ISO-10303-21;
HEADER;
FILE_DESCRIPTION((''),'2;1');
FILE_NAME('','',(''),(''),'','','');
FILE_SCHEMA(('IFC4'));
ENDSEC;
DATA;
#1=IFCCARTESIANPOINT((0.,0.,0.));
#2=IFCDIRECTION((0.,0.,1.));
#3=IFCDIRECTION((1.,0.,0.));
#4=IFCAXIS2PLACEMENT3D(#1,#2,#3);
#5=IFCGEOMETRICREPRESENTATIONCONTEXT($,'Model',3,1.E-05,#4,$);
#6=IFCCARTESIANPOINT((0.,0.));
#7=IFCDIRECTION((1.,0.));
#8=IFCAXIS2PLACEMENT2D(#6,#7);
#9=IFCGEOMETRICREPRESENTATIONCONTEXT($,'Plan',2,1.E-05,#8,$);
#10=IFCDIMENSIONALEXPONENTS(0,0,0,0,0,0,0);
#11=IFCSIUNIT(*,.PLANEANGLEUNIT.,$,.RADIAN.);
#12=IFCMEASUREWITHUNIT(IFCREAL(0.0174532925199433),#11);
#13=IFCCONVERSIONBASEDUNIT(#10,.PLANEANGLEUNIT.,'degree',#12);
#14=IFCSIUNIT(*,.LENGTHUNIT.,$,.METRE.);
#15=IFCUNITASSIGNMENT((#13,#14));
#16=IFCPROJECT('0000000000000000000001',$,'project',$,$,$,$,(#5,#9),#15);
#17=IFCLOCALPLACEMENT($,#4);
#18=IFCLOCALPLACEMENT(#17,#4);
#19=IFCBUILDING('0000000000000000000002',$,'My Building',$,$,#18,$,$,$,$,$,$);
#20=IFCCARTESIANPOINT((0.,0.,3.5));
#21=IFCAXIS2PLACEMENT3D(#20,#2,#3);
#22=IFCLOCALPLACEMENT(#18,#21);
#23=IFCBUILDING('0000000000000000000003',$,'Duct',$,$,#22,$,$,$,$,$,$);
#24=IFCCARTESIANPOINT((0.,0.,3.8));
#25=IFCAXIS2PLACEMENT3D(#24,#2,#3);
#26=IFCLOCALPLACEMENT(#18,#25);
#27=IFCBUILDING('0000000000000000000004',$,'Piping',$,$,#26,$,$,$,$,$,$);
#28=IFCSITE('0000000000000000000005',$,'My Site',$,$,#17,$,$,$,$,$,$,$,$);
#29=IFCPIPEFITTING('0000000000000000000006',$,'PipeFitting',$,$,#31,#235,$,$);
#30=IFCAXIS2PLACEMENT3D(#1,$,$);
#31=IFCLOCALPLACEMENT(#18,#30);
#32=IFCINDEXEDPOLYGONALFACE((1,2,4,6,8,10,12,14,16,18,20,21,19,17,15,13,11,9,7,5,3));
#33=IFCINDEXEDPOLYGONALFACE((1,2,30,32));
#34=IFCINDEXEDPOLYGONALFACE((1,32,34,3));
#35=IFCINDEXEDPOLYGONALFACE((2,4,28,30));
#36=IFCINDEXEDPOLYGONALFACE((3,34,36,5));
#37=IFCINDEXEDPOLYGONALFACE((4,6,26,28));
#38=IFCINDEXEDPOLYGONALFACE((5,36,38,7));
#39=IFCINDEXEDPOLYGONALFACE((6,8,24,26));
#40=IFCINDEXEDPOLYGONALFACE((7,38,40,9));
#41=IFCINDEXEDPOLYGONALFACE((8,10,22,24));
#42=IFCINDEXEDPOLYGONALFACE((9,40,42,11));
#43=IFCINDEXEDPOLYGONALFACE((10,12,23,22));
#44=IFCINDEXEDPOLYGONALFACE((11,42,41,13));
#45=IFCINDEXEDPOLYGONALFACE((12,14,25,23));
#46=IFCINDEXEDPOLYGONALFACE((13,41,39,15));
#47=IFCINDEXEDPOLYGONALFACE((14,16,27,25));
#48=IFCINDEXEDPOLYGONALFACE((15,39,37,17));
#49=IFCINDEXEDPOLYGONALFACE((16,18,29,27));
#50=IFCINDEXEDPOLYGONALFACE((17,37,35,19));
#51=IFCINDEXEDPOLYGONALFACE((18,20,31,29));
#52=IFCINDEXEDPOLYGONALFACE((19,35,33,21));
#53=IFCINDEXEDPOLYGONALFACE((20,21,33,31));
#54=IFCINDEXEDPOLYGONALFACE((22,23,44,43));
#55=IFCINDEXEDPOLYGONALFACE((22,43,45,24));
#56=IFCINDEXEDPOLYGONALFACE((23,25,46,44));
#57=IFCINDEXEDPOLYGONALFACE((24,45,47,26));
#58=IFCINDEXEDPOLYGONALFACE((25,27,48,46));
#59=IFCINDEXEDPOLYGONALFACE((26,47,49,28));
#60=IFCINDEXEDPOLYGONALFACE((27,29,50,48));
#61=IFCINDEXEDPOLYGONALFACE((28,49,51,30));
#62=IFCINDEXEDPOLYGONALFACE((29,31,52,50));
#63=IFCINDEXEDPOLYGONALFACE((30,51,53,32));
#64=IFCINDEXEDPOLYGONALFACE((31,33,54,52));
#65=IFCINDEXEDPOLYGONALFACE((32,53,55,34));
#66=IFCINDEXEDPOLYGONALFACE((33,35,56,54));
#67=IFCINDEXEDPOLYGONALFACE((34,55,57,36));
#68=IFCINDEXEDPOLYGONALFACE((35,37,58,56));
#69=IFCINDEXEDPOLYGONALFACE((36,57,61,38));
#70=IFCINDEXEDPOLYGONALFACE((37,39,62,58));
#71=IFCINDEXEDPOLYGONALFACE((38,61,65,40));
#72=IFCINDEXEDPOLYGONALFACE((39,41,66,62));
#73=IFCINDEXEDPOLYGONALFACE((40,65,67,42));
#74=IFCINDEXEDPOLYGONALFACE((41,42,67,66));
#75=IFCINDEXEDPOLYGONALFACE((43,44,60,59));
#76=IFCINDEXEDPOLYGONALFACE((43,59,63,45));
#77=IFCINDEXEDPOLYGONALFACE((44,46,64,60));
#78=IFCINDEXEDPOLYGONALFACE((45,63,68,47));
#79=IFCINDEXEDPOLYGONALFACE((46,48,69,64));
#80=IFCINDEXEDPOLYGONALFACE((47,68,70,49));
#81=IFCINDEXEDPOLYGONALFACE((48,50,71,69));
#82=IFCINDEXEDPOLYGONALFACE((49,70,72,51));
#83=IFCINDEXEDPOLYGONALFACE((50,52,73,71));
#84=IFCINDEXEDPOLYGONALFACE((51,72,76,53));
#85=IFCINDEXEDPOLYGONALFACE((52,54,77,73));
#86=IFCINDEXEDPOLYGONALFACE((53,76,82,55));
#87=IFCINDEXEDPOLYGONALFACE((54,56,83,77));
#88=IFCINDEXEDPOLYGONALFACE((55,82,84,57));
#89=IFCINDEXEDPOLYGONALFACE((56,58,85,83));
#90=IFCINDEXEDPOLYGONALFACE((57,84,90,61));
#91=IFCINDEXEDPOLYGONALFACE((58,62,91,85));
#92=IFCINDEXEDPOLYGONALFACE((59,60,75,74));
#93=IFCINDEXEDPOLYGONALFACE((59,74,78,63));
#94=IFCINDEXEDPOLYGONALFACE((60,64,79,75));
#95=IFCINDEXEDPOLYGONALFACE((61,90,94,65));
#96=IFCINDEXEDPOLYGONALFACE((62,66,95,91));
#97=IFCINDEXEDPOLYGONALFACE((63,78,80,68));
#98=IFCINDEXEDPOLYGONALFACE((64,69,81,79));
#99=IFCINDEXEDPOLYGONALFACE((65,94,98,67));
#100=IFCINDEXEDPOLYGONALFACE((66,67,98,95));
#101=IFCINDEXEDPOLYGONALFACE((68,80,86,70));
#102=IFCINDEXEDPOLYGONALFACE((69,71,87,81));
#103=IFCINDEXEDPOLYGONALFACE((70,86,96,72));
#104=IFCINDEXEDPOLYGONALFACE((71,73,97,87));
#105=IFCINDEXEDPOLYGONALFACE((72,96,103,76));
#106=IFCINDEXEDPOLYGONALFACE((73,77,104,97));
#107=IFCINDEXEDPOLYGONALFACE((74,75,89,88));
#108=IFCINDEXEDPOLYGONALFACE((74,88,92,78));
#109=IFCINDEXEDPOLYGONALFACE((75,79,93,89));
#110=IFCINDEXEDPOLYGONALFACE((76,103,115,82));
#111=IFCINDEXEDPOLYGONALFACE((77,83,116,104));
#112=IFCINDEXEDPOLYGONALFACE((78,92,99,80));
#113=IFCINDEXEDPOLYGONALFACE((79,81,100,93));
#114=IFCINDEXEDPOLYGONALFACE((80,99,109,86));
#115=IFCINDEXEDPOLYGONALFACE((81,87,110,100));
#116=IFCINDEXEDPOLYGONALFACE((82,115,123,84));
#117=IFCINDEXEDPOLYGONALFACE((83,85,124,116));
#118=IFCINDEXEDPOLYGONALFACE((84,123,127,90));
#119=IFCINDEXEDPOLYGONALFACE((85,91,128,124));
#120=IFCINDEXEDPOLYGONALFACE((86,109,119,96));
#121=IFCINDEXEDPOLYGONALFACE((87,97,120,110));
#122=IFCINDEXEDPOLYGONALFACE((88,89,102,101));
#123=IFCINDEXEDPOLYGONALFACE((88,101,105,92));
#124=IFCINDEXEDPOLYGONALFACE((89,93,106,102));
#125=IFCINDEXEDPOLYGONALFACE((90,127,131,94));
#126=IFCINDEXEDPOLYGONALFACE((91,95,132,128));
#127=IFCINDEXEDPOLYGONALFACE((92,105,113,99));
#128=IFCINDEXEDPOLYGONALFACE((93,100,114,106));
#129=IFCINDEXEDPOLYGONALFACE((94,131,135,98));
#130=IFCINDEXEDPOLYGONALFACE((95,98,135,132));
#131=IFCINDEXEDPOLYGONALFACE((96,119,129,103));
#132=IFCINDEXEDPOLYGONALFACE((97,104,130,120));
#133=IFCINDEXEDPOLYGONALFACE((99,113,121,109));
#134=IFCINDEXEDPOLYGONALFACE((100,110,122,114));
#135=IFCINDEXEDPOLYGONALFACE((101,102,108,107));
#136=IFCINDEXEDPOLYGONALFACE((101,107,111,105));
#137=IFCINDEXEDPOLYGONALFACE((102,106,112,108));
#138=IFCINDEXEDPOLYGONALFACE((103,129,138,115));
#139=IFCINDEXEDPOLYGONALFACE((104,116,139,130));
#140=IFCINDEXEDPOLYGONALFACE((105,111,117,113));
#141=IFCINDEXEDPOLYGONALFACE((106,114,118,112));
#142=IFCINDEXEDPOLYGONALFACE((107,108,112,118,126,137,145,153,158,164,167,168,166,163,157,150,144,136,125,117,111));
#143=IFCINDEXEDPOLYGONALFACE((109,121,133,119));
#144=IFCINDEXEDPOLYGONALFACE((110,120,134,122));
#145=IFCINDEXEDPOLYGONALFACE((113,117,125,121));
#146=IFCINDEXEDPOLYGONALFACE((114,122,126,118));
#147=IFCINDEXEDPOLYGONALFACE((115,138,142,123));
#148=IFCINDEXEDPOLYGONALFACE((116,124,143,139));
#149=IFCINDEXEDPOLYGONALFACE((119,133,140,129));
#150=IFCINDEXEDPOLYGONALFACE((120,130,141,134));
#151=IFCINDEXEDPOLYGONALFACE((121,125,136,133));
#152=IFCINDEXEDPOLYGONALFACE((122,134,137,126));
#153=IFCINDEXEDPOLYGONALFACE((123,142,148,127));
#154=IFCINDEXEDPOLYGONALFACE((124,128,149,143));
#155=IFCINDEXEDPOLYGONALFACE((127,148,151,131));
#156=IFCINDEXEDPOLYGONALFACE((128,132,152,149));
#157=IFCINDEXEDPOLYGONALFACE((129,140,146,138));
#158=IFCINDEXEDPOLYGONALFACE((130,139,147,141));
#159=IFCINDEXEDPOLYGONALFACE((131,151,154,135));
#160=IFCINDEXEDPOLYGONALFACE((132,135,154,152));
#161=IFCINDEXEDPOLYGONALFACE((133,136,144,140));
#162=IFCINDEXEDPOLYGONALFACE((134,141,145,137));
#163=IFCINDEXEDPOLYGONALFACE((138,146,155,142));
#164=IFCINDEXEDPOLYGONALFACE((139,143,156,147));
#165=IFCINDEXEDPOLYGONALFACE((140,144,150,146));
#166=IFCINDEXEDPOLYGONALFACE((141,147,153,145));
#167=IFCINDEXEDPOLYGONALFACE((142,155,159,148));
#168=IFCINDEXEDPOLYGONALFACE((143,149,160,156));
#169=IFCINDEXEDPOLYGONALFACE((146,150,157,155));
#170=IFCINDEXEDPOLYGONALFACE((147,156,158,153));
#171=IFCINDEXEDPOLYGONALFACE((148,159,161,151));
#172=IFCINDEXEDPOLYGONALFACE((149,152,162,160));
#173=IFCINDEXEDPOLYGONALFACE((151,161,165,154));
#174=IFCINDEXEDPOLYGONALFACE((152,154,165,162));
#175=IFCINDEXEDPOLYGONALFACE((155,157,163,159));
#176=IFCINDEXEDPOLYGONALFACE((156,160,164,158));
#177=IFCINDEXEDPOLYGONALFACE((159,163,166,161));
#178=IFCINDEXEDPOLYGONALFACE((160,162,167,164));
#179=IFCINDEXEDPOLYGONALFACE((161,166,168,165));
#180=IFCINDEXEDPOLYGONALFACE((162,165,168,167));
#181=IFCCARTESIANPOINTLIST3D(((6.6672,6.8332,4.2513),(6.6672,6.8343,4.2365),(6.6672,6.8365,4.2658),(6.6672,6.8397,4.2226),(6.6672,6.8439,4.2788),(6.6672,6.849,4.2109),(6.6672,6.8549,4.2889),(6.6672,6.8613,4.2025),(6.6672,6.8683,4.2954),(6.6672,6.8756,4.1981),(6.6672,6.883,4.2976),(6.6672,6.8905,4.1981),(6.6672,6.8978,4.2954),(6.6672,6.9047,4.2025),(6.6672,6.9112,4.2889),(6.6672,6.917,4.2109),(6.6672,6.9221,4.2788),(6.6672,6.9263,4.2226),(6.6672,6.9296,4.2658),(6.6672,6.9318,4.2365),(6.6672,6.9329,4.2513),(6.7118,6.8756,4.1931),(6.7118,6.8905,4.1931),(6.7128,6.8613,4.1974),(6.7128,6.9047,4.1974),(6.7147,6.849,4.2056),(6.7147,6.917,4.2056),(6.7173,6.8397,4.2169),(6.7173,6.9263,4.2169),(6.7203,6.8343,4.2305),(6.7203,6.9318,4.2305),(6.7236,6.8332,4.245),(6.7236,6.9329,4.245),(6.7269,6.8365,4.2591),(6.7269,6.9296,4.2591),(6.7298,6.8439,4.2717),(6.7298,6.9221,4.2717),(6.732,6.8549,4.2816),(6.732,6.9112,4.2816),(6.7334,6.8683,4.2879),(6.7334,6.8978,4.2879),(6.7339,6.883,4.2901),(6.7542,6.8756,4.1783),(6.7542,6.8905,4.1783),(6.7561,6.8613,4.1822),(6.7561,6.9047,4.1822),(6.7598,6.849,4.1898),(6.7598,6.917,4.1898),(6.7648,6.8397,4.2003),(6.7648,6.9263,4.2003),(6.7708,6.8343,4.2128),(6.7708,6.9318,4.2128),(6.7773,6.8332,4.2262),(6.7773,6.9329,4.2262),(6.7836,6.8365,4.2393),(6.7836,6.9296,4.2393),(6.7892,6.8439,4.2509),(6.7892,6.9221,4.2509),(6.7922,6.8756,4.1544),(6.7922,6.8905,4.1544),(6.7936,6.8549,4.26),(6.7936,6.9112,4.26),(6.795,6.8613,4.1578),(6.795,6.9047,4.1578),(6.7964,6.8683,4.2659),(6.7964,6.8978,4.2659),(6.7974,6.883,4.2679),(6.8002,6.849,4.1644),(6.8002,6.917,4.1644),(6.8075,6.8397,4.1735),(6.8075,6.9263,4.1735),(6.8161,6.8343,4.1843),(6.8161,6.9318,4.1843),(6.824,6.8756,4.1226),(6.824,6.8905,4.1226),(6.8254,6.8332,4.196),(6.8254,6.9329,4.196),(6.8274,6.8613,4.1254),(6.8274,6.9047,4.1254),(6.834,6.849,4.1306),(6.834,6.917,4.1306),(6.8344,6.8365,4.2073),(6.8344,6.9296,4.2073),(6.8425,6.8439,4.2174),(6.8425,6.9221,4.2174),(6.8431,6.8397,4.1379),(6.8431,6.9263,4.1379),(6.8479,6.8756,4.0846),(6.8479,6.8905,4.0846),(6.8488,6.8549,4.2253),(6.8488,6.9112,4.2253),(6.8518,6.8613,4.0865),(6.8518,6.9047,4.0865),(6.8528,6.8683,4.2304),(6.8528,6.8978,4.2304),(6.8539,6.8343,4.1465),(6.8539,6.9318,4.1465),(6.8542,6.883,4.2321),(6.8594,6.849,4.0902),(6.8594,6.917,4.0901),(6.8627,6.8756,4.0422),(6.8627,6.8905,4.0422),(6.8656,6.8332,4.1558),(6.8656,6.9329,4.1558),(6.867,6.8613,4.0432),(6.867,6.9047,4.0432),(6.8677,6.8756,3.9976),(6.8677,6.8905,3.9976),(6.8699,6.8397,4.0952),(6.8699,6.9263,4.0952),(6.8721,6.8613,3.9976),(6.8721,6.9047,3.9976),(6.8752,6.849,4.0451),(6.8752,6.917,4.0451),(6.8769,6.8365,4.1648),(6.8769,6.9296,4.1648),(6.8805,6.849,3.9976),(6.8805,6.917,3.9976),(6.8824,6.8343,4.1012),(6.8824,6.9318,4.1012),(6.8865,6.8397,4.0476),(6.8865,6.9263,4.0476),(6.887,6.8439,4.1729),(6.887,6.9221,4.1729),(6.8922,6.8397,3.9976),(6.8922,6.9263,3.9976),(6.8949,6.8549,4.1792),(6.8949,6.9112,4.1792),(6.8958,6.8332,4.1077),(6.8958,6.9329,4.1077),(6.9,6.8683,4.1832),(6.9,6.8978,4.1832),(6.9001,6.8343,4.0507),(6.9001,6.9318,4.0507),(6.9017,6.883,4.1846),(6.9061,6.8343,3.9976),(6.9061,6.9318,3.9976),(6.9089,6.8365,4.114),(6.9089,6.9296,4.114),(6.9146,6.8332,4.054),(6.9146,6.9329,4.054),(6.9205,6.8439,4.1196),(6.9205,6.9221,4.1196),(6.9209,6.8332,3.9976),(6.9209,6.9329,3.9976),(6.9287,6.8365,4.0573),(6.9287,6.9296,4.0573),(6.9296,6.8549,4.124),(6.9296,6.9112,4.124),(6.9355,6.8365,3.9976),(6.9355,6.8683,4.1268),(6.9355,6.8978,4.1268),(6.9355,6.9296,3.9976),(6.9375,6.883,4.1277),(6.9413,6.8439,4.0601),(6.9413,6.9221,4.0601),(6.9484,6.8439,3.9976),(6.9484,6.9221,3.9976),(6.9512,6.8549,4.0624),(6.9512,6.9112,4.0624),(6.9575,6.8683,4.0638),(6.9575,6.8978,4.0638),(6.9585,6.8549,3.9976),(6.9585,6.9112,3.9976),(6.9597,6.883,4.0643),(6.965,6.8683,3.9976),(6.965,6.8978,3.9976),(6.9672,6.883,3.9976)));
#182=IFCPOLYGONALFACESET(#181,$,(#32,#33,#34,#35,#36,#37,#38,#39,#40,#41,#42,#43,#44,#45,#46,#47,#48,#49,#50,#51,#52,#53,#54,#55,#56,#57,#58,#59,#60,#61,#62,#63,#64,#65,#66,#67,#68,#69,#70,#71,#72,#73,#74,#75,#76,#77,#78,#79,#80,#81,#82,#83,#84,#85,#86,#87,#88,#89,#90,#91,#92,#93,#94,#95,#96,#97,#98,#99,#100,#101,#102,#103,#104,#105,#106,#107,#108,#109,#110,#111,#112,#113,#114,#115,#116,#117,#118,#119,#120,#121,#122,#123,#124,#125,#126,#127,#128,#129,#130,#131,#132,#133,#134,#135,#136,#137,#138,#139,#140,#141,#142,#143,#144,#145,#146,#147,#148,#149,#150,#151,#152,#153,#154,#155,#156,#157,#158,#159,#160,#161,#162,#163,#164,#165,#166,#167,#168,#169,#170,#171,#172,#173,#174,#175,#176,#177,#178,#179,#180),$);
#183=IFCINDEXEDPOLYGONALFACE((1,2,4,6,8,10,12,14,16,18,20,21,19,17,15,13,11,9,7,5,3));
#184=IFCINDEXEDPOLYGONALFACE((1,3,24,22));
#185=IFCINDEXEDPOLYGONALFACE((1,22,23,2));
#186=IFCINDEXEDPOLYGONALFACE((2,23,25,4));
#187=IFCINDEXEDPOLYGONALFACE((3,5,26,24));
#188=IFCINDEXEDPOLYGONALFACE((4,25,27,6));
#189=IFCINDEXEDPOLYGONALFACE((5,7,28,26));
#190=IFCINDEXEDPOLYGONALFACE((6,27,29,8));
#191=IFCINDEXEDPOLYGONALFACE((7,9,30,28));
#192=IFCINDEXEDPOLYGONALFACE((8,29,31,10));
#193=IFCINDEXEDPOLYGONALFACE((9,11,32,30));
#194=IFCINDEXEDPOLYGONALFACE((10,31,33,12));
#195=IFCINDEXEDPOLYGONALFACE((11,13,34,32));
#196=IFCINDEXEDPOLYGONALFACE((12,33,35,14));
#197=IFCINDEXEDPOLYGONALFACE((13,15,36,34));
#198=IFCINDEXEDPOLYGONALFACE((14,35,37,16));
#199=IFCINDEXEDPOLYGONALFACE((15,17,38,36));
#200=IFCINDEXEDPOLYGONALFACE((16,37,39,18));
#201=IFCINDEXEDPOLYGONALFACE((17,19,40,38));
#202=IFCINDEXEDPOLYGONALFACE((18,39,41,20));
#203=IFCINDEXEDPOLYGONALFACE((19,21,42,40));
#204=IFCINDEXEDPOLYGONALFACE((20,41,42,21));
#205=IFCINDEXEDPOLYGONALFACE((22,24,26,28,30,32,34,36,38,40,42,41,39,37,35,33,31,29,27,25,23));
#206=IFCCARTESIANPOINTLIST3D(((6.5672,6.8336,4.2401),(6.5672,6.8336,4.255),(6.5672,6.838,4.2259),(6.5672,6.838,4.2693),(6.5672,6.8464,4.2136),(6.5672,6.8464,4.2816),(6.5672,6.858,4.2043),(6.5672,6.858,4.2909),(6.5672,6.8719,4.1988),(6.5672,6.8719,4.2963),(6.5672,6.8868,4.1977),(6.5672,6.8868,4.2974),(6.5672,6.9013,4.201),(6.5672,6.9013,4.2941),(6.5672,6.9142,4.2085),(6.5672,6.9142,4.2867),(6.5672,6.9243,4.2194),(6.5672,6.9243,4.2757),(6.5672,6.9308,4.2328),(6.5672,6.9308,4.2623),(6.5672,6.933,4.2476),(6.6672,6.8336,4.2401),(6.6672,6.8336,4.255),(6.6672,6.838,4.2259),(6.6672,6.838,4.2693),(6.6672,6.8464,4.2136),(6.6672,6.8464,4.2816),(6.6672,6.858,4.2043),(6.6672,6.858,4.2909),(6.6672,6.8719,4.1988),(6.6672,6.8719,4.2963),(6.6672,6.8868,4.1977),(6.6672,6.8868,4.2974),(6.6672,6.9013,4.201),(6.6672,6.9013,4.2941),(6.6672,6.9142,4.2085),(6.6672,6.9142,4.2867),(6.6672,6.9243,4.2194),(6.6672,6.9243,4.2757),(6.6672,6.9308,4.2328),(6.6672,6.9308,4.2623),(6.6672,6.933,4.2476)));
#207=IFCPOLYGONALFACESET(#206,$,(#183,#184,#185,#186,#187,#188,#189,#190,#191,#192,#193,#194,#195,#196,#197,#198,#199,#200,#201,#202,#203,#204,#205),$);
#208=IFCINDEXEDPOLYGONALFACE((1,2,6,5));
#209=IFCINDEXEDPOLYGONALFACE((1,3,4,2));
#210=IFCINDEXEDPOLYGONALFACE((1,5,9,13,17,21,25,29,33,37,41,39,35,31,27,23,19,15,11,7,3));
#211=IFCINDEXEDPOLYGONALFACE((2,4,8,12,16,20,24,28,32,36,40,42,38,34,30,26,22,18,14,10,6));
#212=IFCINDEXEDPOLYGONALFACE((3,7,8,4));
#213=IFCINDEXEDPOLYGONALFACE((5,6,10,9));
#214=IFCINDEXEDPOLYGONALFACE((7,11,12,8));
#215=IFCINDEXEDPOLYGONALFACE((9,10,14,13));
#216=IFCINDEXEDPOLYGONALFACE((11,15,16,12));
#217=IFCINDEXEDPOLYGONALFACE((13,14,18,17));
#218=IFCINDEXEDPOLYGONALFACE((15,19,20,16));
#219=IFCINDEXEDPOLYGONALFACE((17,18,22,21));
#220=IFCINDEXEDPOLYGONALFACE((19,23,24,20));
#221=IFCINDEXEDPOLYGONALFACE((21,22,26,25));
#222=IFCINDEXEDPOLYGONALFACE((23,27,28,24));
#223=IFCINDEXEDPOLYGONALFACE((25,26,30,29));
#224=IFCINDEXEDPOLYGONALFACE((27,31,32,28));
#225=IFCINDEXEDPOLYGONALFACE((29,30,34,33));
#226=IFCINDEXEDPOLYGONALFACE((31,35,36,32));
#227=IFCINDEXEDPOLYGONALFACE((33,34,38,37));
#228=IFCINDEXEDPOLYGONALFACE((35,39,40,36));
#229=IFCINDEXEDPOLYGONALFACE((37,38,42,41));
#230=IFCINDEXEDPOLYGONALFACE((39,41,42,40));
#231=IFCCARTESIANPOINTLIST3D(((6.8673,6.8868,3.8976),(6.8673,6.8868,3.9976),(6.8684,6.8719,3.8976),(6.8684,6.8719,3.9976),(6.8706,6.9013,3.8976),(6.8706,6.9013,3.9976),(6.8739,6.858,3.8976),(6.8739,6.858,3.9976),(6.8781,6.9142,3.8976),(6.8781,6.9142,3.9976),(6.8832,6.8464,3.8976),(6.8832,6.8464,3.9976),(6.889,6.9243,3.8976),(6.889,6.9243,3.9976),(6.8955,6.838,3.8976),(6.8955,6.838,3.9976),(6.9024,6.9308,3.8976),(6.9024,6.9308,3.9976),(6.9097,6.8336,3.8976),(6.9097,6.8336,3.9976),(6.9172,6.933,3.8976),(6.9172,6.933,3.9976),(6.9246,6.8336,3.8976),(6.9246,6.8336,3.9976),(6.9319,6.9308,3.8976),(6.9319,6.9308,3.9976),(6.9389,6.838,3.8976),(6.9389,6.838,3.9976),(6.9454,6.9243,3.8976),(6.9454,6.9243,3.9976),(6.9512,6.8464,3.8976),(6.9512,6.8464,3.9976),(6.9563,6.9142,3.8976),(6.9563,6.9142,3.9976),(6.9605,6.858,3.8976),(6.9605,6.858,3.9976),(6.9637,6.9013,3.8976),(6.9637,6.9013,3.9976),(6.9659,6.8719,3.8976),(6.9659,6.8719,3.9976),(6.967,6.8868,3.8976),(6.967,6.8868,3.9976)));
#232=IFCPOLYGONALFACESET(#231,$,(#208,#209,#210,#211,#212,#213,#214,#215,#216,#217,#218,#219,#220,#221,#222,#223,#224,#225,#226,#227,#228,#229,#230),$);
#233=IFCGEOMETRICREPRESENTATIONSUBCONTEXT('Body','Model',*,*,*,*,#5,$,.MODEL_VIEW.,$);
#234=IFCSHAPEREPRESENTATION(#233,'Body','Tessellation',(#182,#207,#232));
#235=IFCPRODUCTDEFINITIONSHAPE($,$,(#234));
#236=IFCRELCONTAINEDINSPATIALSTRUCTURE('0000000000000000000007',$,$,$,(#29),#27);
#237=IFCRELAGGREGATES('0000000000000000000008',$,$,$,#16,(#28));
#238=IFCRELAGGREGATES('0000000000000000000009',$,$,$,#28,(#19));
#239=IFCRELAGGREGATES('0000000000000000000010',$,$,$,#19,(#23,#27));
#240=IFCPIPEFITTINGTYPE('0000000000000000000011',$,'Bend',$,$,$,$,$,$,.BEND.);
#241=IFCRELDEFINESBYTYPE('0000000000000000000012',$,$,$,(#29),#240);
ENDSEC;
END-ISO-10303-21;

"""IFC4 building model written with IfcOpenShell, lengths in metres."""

from ifc_helpers import new_model, entity, si_unit, converted_unit, frame, origin_with_axes, origin_2d_with_axis, place, context, subcontext, project, spatial, circle, extrude, source, transform, mapped, type_object, type_shapes, element, save


model = new_model("IFC4")

# Units and contexts
model_context = context("Model", 3, precision=1e-05, world=origin_with_axes())
plan_context = context("Plan", 2, precision=1e-05, world=origin_2d_with_axis())
body_context = subcontext(model_context, "Body", "Model", "MODEL_VIEW")
ifc_project = project(units=[converted_unit("PLANEANGLEUNIT", "degree", entity("IfcReal", 0.0174532925199433), si_unit("PLANEANGLEUNIT", "RADIAN"), dimensions=[0, 0, 0, 0, 0, 0, 0]), si_unit("LENGTHUNIT", "METRE")], contexts=[model_context, plan_context])

# Site, building
site_placement = place(None, origin_with_axes())
site = spatial("IfcSite", under=ifc_project, at=site_placement, Name="My Site")
building_1_placement = place(site_placement, origin_with_axes())
building_1 = spatial("IfcBuilding", under=site, at=building_1_placement, Name="My Building")

# Shared definitions
building_2_placement = place(building_1_placement, frame((0.0, 0.0, 3.5), z_axis=(0.0, 0.0, 1.0), x_axis=(1.0, 0.0, 0.0)))
building_2 = spatial("IfcBuilding", under=building_1, at=building_2_placement, Name="Duct")

# Shared definitions
building_3_placement = place(building_1_placement, frame((0.0, 0.0, 3.8), z_axis=(0.0, 0.0, 1.0), x_axis=(1.0, 0.0, 0.0)))
building_3 = spatial("IfcBuilding", under=building_1, at=building_3_placement, Name="Piping")

# Pipe fitting
pipe_fitting_type_1 = type_object("IfcPipeFittingType", Name="Bend", PredefinedType="BEND")
shared_shape = source(origin_with_axes(), body_context, "Body", "SolidModel", [
    entity("IfcSweptDiskSolid", entity("IfcIndexedPolyCurve", entity("IfcCartesianPointList3D", [[0.0, 0.0, 0.1], [0.0, -0.0732, 0.2768], [0.0, -0.25, 0.35]]), [entity("IfcArcIndex", [1, 2, 3])]), 0.05),
    extrude(circle(Radius=0.05), origin_with_axes(), (0.0, 0.0, 1.0), 0.1),
    extrude(circle(Radius=0.05), frame((0.0, -0.25, 0.35), z_axis=(0.0, -1.0, -0.000001), x_axis=(1.0, 0.0, 0.0)), (0.0, 0.0, 1.0), 0.1),
])
type_shapes(pipe_fitting_type_1, [shared_shape])
for number, where, z_axis, x_axis, name in (
    (1, (6.5672, 6.883, 0.4476), (1.0, -0.000001, 0.000001), (0.000001, 1.0, 0.0), "PipeFitting"),
):
    element("IfcPipeFitting", number, at=place(building_3_placement, frame(where, z_axis=z_axis, x_axis=x_axis)), inside=building_3, type_object=pipe_fitting_type_1, Name=name, context=body_context, shape_type="MappedRepresentation", body=[
        mapped(shared_shape, transform((0.0, 0.0, 0.0), x_axis=(1.0, 0.0, 0.0), y_axis=(0.0, 1.0, 0.0), z_axis=(0.0, 0.0, 1.0), scale=1.0)),
    ])

save(model, "model.ifc")
